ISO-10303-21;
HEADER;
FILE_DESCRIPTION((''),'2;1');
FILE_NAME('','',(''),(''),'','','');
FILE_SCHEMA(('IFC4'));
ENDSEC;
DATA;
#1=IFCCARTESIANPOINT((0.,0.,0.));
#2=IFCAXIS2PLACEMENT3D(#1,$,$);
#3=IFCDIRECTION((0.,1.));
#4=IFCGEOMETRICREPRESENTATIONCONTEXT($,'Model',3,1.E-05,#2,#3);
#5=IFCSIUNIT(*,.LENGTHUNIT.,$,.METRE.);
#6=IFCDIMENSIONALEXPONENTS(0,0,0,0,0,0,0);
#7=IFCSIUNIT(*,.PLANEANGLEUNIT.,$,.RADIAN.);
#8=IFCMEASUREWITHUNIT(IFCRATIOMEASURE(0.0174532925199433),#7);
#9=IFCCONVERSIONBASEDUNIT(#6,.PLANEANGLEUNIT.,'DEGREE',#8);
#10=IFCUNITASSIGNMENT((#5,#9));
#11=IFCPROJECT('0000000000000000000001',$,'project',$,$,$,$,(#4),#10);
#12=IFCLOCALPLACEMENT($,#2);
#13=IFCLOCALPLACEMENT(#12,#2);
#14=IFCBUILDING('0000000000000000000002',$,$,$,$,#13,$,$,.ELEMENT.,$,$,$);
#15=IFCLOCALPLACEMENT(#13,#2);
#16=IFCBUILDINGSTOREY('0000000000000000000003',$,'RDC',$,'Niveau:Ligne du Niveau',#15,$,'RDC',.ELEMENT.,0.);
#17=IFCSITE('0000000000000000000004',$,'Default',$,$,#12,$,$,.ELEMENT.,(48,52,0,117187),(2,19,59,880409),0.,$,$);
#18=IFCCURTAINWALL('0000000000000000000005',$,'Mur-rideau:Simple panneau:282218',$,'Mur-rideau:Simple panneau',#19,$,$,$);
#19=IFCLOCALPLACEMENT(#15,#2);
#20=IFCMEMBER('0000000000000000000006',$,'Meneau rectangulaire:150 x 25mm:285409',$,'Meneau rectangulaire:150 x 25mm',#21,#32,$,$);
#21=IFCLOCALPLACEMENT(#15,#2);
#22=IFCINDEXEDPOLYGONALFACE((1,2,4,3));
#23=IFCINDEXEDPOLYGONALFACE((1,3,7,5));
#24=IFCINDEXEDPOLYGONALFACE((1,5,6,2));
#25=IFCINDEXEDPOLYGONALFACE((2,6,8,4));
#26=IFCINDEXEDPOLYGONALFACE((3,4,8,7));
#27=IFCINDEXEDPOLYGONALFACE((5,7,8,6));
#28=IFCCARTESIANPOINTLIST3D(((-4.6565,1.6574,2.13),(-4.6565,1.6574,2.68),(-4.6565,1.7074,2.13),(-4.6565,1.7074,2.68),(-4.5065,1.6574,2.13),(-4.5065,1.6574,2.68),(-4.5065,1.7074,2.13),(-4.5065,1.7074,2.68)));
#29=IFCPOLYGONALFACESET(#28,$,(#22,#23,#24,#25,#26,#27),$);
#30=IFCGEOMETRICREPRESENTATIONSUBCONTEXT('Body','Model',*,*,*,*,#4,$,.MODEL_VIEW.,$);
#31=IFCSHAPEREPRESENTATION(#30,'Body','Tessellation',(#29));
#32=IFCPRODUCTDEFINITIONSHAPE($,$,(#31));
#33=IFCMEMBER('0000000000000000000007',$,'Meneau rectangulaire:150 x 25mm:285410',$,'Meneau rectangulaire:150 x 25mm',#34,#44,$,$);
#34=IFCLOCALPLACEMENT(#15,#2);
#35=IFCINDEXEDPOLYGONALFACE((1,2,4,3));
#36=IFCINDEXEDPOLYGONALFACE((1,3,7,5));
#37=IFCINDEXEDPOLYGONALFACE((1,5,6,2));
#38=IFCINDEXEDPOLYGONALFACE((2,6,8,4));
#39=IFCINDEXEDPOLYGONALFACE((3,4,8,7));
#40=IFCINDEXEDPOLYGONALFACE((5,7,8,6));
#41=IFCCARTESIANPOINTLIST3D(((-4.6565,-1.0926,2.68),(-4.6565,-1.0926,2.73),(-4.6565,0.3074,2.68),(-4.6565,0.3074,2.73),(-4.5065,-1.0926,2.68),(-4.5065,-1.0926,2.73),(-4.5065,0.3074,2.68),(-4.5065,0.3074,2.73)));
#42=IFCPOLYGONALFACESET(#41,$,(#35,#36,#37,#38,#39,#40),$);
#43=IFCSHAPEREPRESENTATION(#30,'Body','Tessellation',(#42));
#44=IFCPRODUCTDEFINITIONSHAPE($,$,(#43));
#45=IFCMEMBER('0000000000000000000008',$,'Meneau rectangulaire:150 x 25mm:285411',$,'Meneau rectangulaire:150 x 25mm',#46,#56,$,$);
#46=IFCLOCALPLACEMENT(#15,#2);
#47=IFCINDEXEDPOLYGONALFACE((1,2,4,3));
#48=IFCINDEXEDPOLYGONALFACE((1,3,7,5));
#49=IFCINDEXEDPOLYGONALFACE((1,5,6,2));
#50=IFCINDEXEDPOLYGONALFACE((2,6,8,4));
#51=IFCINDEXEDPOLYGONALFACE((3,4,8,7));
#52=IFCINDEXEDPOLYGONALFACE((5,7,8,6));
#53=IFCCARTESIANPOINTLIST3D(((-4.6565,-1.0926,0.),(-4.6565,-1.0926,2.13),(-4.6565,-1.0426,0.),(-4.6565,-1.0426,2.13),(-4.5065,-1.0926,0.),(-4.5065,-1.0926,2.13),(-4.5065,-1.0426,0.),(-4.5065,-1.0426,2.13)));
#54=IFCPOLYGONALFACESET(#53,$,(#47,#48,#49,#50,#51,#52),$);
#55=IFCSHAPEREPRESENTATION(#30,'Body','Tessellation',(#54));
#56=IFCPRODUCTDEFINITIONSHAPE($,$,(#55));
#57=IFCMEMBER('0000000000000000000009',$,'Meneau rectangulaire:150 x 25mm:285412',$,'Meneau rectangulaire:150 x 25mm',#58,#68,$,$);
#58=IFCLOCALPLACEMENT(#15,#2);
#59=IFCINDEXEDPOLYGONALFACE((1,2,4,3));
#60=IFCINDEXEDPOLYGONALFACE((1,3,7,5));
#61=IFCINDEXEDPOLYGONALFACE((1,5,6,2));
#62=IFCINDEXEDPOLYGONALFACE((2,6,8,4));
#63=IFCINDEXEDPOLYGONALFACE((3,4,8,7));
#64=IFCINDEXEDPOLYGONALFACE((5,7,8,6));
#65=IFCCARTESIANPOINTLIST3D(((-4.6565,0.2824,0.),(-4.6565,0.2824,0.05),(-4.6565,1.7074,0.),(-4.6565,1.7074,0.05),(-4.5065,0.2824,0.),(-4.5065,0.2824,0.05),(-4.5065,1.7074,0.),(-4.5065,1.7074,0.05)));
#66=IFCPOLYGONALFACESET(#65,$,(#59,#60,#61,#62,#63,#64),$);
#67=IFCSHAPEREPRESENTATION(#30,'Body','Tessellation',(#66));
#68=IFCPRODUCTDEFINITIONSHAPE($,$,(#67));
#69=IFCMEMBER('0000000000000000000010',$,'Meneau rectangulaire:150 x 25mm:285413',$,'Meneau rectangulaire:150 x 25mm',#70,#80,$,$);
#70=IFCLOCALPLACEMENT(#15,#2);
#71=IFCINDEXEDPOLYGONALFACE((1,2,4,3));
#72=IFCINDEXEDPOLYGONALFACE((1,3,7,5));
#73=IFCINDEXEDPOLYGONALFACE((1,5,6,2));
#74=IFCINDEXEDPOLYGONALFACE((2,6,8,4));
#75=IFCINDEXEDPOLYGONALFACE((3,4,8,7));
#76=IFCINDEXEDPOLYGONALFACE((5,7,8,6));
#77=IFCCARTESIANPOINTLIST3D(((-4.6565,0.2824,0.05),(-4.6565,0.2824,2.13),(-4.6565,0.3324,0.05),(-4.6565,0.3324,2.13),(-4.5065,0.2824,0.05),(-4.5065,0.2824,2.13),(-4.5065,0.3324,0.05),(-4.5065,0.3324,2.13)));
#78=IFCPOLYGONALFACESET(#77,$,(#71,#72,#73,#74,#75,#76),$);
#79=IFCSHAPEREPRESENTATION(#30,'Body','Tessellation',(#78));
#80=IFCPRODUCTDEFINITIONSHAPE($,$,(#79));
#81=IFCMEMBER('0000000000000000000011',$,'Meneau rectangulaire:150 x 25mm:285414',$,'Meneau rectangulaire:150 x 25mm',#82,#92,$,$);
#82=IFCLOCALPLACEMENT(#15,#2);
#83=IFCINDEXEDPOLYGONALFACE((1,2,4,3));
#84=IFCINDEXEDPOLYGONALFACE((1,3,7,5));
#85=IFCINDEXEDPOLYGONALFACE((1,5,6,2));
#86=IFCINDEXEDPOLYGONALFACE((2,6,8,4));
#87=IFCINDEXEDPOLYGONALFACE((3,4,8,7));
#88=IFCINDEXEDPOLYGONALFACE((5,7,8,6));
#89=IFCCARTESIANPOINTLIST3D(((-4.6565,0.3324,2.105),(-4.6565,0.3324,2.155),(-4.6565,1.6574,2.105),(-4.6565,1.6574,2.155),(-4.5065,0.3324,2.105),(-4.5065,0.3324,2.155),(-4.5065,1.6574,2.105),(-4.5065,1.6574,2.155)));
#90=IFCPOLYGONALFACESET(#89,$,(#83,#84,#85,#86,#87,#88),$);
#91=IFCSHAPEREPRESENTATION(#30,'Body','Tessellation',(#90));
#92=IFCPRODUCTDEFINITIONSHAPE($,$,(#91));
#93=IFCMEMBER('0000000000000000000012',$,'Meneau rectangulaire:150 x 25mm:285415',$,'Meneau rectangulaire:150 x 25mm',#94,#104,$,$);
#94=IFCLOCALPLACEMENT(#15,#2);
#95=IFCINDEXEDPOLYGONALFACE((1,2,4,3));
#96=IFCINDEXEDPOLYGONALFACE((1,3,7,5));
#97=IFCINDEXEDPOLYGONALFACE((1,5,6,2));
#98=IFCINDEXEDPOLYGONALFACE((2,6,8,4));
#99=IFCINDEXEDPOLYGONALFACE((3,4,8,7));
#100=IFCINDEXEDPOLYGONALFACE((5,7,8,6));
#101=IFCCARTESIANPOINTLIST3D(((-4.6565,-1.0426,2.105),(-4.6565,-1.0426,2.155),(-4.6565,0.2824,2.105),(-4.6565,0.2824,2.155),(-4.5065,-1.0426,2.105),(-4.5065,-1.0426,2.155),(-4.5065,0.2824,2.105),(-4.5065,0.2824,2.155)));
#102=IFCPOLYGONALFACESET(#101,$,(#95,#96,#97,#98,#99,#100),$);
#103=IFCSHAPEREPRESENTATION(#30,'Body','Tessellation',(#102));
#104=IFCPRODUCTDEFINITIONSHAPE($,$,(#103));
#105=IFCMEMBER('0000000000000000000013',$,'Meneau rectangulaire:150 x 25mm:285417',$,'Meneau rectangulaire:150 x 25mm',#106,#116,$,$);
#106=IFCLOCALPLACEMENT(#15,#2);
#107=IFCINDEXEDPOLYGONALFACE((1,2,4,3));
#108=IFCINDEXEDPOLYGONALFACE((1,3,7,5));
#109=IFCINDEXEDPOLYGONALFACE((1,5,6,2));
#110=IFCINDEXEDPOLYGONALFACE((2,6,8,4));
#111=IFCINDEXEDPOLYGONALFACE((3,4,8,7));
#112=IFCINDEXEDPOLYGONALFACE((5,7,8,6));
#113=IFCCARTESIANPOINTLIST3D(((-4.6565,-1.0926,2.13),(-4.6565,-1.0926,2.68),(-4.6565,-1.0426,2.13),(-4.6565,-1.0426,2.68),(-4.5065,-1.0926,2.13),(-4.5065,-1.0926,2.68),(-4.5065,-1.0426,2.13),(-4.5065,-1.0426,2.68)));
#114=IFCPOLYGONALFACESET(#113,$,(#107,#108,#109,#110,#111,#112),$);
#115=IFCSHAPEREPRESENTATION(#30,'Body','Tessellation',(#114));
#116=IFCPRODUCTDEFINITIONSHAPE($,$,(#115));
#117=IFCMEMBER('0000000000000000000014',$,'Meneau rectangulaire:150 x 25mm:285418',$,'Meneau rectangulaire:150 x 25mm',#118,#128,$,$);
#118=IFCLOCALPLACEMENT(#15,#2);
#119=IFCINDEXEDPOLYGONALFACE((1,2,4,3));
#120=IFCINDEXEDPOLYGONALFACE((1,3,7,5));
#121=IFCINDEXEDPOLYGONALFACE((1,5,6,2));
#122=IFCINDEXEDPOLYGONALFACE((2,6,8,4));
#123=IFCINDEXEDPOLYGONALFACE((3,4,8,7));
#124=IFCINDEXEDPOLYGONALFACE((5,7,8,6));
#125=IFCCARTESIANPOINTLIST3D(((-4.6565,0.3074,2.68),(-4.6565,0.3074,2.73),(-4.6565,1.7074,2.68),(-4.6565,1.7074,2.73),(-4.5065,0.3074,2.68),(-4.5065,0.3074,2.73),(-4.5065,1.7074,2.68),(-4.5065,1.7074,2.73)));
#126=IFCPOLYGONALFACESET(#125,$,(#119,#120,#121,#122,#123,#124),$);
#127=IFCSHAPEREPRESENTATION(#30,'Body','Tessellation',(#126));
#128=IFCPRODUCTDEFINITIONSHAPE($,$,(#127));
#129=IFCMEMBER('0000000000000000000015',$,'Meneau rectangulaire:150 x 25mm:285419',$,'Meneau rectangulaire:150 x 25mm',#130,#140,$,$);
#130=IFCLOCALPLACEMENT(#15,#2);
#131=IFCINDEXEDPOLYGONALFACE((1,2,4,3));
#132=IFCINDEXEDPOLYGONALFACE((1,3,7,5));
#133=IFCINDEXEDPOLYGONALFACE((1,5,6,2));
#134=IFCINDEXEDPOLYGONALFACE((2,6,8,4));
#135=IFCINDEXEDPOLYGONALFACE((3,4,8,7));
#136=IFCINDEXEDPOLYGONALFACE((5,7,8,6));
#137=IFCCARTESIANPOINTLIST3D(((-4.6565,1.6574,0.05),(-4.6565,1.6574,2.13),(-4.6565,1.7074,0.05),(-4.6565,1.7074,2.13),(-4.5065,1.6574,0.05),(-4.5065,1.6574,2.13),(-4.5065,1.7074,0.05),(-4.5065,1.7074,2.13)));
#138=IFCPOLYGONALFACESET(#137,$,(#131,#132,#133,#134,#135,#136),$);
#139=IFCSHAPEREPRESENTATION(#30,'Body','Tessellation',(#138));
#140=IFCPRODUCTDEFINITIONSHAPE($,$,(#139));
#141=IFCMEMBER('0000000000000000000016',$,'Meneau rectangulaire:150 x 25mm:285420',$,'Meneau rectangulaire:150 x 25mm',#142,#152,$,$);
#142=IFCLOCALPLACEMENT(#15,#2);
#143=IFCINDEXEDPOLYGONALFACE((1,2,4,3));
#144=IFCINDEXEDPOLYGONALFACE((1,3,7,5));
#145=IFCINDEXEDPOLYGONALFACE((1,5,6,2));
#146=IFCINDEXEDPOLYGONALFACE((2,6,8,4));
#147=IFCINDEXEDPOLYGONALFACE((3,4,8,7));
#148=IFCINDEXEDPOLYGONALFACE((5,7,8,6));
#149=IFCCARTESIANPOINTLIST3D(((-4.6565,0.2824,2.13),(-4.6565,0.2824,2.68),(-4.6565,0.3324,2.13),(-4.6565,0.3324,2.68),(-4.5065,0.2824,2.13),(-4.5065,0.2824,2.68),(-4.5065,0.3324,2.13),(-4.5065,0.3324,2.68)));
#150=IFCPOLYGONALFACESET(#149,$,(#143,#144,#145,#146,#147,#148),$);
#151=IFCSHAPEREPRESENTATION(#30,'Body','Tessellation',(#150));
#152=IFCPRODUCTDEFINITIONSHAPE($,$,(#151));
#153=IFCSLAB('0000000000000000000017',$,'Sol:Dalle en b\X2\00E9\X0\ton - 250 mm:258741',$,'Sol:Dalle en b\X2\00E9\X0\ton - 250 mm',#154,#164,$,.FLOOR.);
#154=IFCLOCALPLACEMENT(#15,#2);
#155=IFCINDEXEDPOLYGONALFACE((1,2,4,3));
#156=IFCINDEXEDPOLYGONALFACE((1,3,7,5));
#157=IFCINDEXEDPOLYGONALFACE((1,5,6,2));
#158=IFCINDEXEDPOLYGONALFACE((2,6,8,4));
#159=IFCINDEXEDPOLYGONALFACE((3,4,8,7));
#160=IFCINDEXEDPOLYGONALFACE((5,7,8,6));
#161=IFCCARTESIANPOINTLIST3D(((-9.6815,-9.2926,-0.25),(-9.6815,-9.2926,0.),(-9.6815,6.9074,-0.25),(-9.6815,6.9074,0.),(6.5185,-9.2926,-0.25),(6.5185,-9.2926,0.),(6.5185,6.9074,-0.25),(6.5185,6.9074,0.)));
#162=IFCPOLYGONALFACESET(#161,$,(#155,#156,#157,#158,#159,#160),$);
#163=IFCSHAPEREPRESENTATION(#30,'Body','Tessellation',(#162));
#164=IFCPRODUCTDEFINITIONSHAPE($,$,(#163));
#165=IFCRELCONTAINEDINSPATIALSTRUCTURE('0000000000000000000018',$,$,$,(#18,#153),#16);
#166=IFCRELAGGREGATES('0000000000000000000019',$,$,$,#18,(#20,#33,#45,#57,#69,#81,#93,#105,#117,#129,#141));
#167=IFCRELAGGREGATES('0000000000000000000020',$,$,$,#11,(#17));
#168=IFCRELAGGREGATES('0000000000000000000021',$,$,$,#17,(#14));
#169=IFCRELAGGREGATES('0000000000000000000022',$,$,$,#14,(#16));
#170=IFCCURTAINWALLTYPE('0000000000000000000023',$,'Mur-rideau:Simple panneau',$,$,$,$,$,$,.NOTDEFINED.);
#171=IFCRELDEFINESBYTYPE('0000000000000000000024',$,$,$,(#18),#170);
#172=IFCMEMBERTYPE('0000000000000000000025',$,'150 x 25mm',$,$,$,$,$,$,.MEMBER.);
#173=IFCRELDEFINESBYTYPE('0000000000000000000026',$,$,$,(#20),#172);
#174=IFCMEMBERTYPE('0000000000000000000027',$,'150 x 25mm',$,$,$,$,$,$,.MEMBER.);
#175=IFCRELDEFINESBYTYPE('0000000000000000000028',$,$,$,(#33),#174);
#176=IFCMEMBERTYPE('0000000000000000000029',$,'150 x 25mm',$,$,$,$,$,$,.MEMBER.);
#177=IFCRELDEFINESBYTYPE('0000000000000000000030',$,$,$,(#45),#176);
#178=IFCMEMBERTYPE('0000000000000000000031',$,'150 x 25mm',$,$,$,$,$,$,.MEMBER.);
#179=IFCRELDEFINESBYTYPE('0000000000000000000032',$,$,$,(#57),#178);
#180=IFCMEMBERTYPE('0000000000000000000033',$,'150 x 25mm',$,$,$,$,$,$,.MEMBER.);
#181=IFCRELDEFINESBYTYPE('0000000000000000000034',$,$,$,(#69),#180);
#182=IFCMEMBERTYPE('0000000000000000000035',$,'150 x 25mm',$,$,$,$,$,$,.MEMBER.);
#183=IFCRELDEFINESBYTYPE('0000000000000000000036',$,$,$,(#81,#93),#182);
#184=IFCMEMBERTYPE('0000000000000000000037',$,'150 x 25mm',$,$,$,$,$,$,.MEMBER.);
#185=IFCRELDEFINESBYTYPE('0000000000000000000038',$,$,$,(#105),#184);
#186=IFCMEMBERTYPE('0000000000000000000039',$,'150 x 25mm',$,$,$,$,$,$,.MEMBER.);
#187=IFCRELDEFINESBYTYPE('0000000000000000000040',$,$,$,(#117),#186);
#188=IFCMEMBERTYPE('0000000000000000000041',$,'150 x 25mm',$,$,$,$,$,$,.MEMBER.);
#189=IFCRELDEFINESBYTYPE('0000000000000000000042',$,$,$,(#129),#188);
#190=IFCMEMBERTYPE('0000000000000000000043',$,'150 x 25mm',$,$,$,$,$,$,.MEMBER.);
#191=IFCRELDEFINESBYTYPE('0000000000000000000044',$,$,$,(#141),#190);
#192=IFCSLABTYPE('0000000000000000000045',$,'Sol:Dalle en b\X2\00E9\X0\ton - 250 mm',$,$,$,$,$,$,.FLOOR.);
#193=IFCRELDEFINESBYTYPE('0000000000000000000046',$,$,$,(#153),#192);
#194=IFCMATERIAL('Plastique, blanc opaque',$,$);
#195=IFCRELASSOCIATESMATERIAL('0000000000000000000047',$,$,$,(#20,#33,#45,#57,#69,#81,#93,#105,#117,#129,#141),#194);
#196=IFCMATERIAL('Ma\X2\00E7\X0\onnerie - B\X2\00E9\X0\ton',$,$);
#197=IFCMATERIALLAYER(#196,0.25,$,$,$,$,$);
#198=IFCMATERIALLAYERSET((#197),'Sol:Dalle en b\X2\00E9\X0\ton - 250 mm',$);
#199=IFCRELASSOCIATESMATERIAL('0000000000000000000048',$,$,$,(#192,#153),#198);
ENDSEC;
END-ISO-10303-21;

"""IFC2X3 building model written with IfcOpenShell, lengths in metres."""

from ifc_helpers import new_model, entity, si_unit, converted_unit, direction, frame, frame_2d, origin, origin_2d_with_axis, place, context, subcontext, project, spatial, rectangle, extrude, source, transform, mapped, material, layer, layer_set, layer_usage, type_object, type_shapes, element, aggregate, save


model = new_model("IFC2X3")

# Units and contexts
model_context = context("Model", 3, precision=1e-05, world=origin(), true_north=direction((0.0, 1.0)))
body_context = subcontext(model_context, "Body", "Model", "MODEL_VIEW")
ifc_project = project(units=[si_unit("LENGTHUNIT", "METRE"), converted_unit("PLANEANGLEUNIT", "DEGREE", entity("IfcRatioMeasure", 0.0174532925199433), si_unit("PLANEANGLEUNIT", "RADIAN"), dimensions=[0, 0, 0, 0, 0, 0, 0])], contexts=[model_context])

# Site, building, storey
site_placement = place(None, origin())
site = spatial("IfcSite", under=ifc_project, at=site_placement, Name="Default", CompositionType="ELEMENT", RefLatitude=(48, 52, 0, 117187), RefLongitude=(2, 19, 59, 880409), RefElevation=0.0)
building_placement = place(site_placement, origin())
building = spatial("IfcBuilding", under=site, at=building_placement, CompositionType="ELEMENT")
storey_placement = place(building_placement, origin())
storey = spatial("IfcBuildingStorey", under=building, at=storey_placement, Name="RDC", ObjectType="Niveau:Ligne du Niveau", LongName="RDC", CompositionType="ELEMENT", Elevation=0.0)

# Curtain wall, members
curtain_wall_type = type_object("IfcCurtainWallType", Name="Mur-rideau:Simple panneau", PredefinedType="NOTDEFINED")
curtain_wall_placement = place(storey_placement, origin())
curtain_wall = element("IfcCurtainWall", 1, at=curtain_wall_placement, inside=storey, type_object=curtain_wall_type, Name="Mur-rideau:Simple panneau:282218", ObjectType="Mur-rideau:Simple panneau")
ifc_material_1 = material(Name="Plastique, blanc opaque")
member_type_1 = type_object("IfcMemberType", Name="150 x 25mm", PredefinedType="MEMBER")
shared_shape_1 = source(origin(), body_context, "Body", "SweptSolid", [
    extrude(rectangle(XDim=0.15, YDim=0.05, at=origin_2d_with_axis()), frame((-0.025, 0.0, -0.55), z_axis=(0.0, 0.0, 1.0), x_axis=(0.0, -1.0, 0.0)), (0.0, 0.0, 1.0), 0.55),
])
type_shapes(member_type_1, [shared_shape_1])
member_1_placement = place(storey_placement, frame((-4.5815, 1.7074, 2.68), z_axis=(0.0, 0.0, 1.0), x_axis=(0.0, 1.0, 0.0)))
member_1 = element("IfcMember", 2, at=member_1_placement, type_object=member_type_1, material=ifc_material_1, Name="Meneau rectangulaire:150 x 25mm:285409", ObjectType="Meneau rectangulaire:150 x 25mm", context=body_context, shape_type="MappedRepresentation", body=[
    mapped(shared_shape_1, transform((0.0, 0.0, 0.0), scale=1.0)),
])
member_type_2 = type_object("IfcMemberType", Name="150 x 25mm", PredefinedType="MEMBER")
shared_shape_2 = source(origin(), body_context, "Body", "SweptSolid", [
    extrude(rectangle(XDim=0.15, YDim=0.05, at=origin_2d_with_axis()), frame((-0.025, 0.0, -1.4), z_axis=(0.0, 0.0, 1.0), x_axis=(0.0, -1.0, 0.0)), (0.0, 0.0, 1.0), 1.4),
])
type_shapes(member_type_2, [shared_shape_2])
member_2_placement = place(storey_placement, frame((-4.5815, -1.0926, 2.73), z_axis=(0.0, -1.0, 0.0), x_axis=(0.0, 0.0, 1.0)))
member_2 = element("IfcMember", 3, at=member_2_placement, type_object=member_type_2, material=ifc_material_1, Name="Meneau rectangulaire:150 x 25mm:285410", ObjectType="Meneau rectangulaire:150 x 25mm", context=body_context, shape_type="MappedRepresentation", body=[
    mapped(shared_shape_2, transform((0.0, 0.0, 0.0), scale=1.0)),
])
member_type_3 = type_object("IfcMemberType", Name="150 x 25mm", PredefinedType="MEMBER")
shared_shape_3 = source(origin(), body_context, "Body", "SweptSolid", [
    extrude(rectangle(XDim=0.15, YDim=0.05, at=origin_2d_with_axis()), frame((-0.025, 0.0, -2.13), z_axis=(0.0, 0.0, 1.0), x_axis=(0.0, -1.0, 0.0)), (0.0, 0.0, 1.0), 2.13),
])
type_shapes(member_type_3, [shared_shape_3])
member_3_placement = place(storey_placement, frame((-4.5815, -1.0926, 0.0), z_axis=(0.0, 0.0, -1.0), x_axis=(0.0, -1.0, 0.0)))
member_3 = element("IfcMember", 4, at=member_3_placement, type_object=member_type_3, material=ifc_material_1, Name="Meneau rectangulaire:150 x 25mm:285411", ObjectType="Meneau rectangulaire:150 x 25mm", context=body_context, shape_type="MappedRepresentation", body=[
    mapped(shared_shape_3, transform((0.0, 0.0, 0.0), scale=1.0)),
])
member_type_4 = type_object("IfcMemberType", Name="150 x 25mm", PredefinedType="MEMBER")
shared_shape_4 = source(origin(), body_context, "Body", "SweptSolid", [
    extrude(rectangle(XDim=0.15, YDim=0.05, at=origin_2d_with_axis()), frame((-0.025, 0.0, -1.425), z_axis=(0.0, 0.0, 1.0), x_axis=(0.0, -1.0, 0.0)), (0.0, 0.0, 1.0), 1.425),
])
type_shapes(member_type_4, [shared_shape_4])
member_4_placement = place(storey_placement, frame((-4.5815, 1.7074, 0.0), z_axis=(0.0, 1.0, 0.0), x_axis=(0.0, 0.0, -1.0)))
member_4 = element("IfcMember", 5, at=member_4_placement, type_object=member_type_4, material=ifc_material_1, Name="Meneau rectangulaire:150 x 25mm:285412", ObjectType="Meneau rectangulaire:150 x 25mm", context=body_context, shape_type="MappedRepresentation", body=[
    mapped(shared_shape_4, transform((0.0, 0.0, 0.0), scale=1.0)),
])
member_type_5 = type_object("IfcMemberType", Name="150 x 25mm", PredefinedType="MEMBER")
shared_shape_5 = source(origin(), body_context, "Body", "SweptSolid", [
    extrude(rectangle(XDim=0.15, YDim=0.05, at=origin_2d_with_axis()), frame((0.0, 0.0, -2.08), z_axis=(0.0, 0.0, 1.0), x_axis=(0.0, -1.0, 0.0)), (0.0, 0.0, 1.0), 2.08),
])
type_shapes(member_type_5, [shared_shape_5])
member_5_placement = place(storey_placement, frame((-4.5815, 0.3074, 0.05), z_axis=(0.0, 0.0, -1.0), x_axis=(0.0, -1.0, 0.0)))
member_5 = element("IfcMember", 6, at=member_5_placement, type_object=member_type_5, material=ifc_material_1, Name="Meneau rectangulaire:150 x 25mm:285413", ObjectType="Meneau rectangulaire:150 x 25mm", context=body_context, shape_type="MappedRepresentation", body=[
    mapped(shared_shape_5, transform((0.0, 0.0, 0.0), scale=1.0)),
])
member_type_6 = type_object("IfcMemberType", Name="150 x 25mm", PredefinedType="MEMBER")
shared_shape_6 = source(origin(), body_context, "Body", "SweptSolid", [
    extrude(rectangle(XDim=0.15, YDim=0.05, at=origin_2d_with_axis()), frame((0.0, 0.0, -1.325), z_axis=(0.0, 0.0, 1.0), x_axis=(0.0, -1.0, 0.0)), (0.0, 0.0, 1.0), 1.325),
])
type_shapes(member_type_6, [shared_shape_6])
member_6_placement = place(storey_placement, frame((-4.5815, 0.3324, 2.13), z_axis=(0.0, -1.0, 0.0), x_axis=(0.0, 0.0, 1.0)))
member_6 = element("IfcMember", 7, at=member_6_placement, type_object=member_type_6, material=ifc_material_1, Name="Meneau rectangulaire:150 x 25mm:285414", ObjectType="Meneau rectangulaire:150 x 25mm", context=body_context, shape_type="MappedRepresentation", body=[
    mapped(shared_shape_6, transform((0.0, 0.0, 0.0), scale=1.0)),
])
member_7_placement = place(storey_placement, frame((-4.5815, -1.0426, 2.13), z_axis=(0.0, -1.0, 0.0), x_axis=(0.0, 0.0, 1.0)))
member_7 = element("IfcMember", 8, at=member_7_placement, type_object=member_type_6, material=ifc_material_1, Name="Meneau rectangulaire:150 x 25mm:285415", ObjectType="Meneau rectangulaire:150 x 25mm", context=body_context, shape_type="MappedRepresentation", body=[
    mapped(shared_shape_6, transform((0.0, 0.0, 0.0), scale=1.0)),
])
member_type_7 = type_object("IfcMemberType", Name="150 x 25mm", PredefinedType="MEMBER")
shared_shape_7 = source(origin(), body_context, "Body", "SweptSolid", [
    extrude(rectangle(XDim=0.15, YDim=0.05, at=origin_2d_with_axis()), frame((-0.025, 0.0, -0.55), z_axis=(0.0, 0.0, 1.0), x_axis=(0.0, -1.0, 0.0)), (0.0, 0.0, 1.0), 0.55),
])
type_shapes(member_type_7, [shared_shape_7])
member_8_placement = place(storey_placement, frame((-4.5815, -1.0926, 2.13), z_axis=(0.0, 0.0, -1.0), x_axis=(0.0, -1.0, 0.0)))
member_8 = element("IfcMember", 9, at=member_8_placement, type_object=member_type_7, material=ifc_material_1, Name="Meneau rectangulaire:150 x 25mm:285417", ObjectType="Meneau rectangulaire:150 x 25mm", context=body_context, shape_type="MappedRepresentation", body=[
    mapped(shared_shape_7, transform((0.0, 0.0, 0.0), scale=1.0)),
])
member_type_8 = type_object("IfcMemberType", Name="150 x 25mm", PredefinedType="MEMBER")
shared_shape_8 = source(origin(), body_context, "Body", "SweptSolid", [
    extrude(rectangle(XDim=0.15, YDim=0.05, at=origin_2d_with_axis()), frame((-0.025, 0.0, -1.4), z_axis=(0.0, 0.0, 1.0), x_axis=(0.0, -1.0, 0.0)), (0.0, 0.0, 1.0), 1.4),
])
type_shapes(member_type_8, [shared_shape_8])
member_9_placement = place(storey_placement, frame((-4.5815, 0.3074, 2.73), z_axis=(0.0, -1.0, 0.0), x_axis=(0.0, 0.0, 1.0)))
member_9 = element("IfcMember", 10, at=member_9_placement, type_object=member_type_8, material=ifc_material_1, Name="Meneau rectangulaire:150 x 25mm:285418", ObjectType="Meneau rectangulaire:150 x 25mm", context=body_context, shape_type="MappedRepresentation", body=[
    mapped(shared_shape_8, transform((0.0, 0.0, 0.0), scale=1.0)),
])
member_type_9 = type_object("IfcMemberType", Name="150 x 25mm", PredefinedType="MEMBER")
shared_shape_9 = source(origin(), body_context, "Body", "SweptSolid", [
    extrude(rectangle(XDim=0.15, YDim=0.05, at=origin_2d_with_axis()), frame((-0.025, 0.0, -2.08), z_axis=(0.0, 0.0, 1.0), x_axis=(0.0, -1.0, 0.0)), (0.0, 0.0, 1.0), 2.08),
])
type_shapes(member_type_9, [shared_shape_9])
member_10_placement = place(storey_placement, frame((-4.5815, 1.7074, 2.13), z_axis=(0.0, 0.0, 1.0), x_axis=(0.0, 1.0, 0.0)))
member_10 = element("IfcMember", 11, at=member_10_placement, type_object=member_type_9, material=ifc_material_1, Name="Meneau rectangulaire:150 x 25mm:285419", ObjectType="Meneau rectangulaire:150 x 25mm", context=body_context, shape_type="MappedRepresentation", body=[
    mapped(shared_shape_9, transform((0.0, 0.0, 0.0), scale=1.0)),
])
member_type_10 = type_object("IfcMemberType", Name="150 x 25mm", PredefinedType="MEMBER")
shared_shape_10 = source(origin(), body_context, "Body", "SweptSolid", [
    extrude(rectangle(XDim=0.15, YDim=0.05, at=origin_2d_with_axis()), frame((0.0, 0.0, -0.55), z_axis=(0.0, 0.0, 1.0), x_axis=(0.0, -1.0, 0.0)), (0.0, 0.0, 1.0), 0.55),
])
type_shapes(member_type_10, [shared_shape_10])
member_11_placement = place(storey_placement, frame((-4.5815, 0.3074, 2.13), z_axis=(0.0, 0.0, -1.0), x_axis=(0.0, -1.0, 0.0)))
member_11 = element("IfcMember", 12, at=member_11_placement, type_object=member_type_10, material=ifc_material_1, Name="Meneau rectangulaire:150 x 25mm:285420", ObjectType="Meneau rectangulaire:150 x 25mm", context=body_context, shape_type="MappedRepresentation", body=[
    mapped(shared_shape_10, transform((0.0, 0.0, 0.0), scale=1.0)),
])

# Slab
ifc_material_2 = material(Name="Maçonnerie - Béton")
ifc_layer_1 = layer(ifc_material_2, 0.25)
ifc_layer_set_1 = layer_set([ifc_layer_1], Name="Sol:Dalle en béton - 250 mm")
ifc_layer_usage_1 = layer_usage(ifc_layer_set_1, "AXIS3", "POSITIVE", 0.0)
slab_type = type_object("IfcSlabType", Name="Sol:Dalle en béton - 250 mm", PredefinedType="FLOOR", material=ifc_layer_set_1)
slab_1_placement = place(storey_placement, origin())
element("IfcSlab", 13, at=slab_1_placement, inside=storey, type_object=slab_type, material=ifc_layer_usage_1, Name="Sol:Dalle en béton - 250 mm:258741", ObjectType="Sol:Dalle en béton - 250 mm", PredefinedType="FLOOR", context=body_context, shape_type="SweptSolid", body=[
    extrude(rectangle(XDim=16.2, YDim=16.2, at=frame_2d((0.0, 0.0), x_axis=(1.0, 0.0))), frame((-1.5815, -1.1926, 0.0), z_axis=(0.0, 0.0, -1.0), x_axis=(0.0, 1.0, 0.0)), (0.0, 0.0, 1.0), 0.25),
])

aggregate(curtain_wall, [member_1, member_2, member_3, member_4, member_5, member_6, member_7, member_8, member_9, member_10, member_11])

save(model, "model.ifc")
